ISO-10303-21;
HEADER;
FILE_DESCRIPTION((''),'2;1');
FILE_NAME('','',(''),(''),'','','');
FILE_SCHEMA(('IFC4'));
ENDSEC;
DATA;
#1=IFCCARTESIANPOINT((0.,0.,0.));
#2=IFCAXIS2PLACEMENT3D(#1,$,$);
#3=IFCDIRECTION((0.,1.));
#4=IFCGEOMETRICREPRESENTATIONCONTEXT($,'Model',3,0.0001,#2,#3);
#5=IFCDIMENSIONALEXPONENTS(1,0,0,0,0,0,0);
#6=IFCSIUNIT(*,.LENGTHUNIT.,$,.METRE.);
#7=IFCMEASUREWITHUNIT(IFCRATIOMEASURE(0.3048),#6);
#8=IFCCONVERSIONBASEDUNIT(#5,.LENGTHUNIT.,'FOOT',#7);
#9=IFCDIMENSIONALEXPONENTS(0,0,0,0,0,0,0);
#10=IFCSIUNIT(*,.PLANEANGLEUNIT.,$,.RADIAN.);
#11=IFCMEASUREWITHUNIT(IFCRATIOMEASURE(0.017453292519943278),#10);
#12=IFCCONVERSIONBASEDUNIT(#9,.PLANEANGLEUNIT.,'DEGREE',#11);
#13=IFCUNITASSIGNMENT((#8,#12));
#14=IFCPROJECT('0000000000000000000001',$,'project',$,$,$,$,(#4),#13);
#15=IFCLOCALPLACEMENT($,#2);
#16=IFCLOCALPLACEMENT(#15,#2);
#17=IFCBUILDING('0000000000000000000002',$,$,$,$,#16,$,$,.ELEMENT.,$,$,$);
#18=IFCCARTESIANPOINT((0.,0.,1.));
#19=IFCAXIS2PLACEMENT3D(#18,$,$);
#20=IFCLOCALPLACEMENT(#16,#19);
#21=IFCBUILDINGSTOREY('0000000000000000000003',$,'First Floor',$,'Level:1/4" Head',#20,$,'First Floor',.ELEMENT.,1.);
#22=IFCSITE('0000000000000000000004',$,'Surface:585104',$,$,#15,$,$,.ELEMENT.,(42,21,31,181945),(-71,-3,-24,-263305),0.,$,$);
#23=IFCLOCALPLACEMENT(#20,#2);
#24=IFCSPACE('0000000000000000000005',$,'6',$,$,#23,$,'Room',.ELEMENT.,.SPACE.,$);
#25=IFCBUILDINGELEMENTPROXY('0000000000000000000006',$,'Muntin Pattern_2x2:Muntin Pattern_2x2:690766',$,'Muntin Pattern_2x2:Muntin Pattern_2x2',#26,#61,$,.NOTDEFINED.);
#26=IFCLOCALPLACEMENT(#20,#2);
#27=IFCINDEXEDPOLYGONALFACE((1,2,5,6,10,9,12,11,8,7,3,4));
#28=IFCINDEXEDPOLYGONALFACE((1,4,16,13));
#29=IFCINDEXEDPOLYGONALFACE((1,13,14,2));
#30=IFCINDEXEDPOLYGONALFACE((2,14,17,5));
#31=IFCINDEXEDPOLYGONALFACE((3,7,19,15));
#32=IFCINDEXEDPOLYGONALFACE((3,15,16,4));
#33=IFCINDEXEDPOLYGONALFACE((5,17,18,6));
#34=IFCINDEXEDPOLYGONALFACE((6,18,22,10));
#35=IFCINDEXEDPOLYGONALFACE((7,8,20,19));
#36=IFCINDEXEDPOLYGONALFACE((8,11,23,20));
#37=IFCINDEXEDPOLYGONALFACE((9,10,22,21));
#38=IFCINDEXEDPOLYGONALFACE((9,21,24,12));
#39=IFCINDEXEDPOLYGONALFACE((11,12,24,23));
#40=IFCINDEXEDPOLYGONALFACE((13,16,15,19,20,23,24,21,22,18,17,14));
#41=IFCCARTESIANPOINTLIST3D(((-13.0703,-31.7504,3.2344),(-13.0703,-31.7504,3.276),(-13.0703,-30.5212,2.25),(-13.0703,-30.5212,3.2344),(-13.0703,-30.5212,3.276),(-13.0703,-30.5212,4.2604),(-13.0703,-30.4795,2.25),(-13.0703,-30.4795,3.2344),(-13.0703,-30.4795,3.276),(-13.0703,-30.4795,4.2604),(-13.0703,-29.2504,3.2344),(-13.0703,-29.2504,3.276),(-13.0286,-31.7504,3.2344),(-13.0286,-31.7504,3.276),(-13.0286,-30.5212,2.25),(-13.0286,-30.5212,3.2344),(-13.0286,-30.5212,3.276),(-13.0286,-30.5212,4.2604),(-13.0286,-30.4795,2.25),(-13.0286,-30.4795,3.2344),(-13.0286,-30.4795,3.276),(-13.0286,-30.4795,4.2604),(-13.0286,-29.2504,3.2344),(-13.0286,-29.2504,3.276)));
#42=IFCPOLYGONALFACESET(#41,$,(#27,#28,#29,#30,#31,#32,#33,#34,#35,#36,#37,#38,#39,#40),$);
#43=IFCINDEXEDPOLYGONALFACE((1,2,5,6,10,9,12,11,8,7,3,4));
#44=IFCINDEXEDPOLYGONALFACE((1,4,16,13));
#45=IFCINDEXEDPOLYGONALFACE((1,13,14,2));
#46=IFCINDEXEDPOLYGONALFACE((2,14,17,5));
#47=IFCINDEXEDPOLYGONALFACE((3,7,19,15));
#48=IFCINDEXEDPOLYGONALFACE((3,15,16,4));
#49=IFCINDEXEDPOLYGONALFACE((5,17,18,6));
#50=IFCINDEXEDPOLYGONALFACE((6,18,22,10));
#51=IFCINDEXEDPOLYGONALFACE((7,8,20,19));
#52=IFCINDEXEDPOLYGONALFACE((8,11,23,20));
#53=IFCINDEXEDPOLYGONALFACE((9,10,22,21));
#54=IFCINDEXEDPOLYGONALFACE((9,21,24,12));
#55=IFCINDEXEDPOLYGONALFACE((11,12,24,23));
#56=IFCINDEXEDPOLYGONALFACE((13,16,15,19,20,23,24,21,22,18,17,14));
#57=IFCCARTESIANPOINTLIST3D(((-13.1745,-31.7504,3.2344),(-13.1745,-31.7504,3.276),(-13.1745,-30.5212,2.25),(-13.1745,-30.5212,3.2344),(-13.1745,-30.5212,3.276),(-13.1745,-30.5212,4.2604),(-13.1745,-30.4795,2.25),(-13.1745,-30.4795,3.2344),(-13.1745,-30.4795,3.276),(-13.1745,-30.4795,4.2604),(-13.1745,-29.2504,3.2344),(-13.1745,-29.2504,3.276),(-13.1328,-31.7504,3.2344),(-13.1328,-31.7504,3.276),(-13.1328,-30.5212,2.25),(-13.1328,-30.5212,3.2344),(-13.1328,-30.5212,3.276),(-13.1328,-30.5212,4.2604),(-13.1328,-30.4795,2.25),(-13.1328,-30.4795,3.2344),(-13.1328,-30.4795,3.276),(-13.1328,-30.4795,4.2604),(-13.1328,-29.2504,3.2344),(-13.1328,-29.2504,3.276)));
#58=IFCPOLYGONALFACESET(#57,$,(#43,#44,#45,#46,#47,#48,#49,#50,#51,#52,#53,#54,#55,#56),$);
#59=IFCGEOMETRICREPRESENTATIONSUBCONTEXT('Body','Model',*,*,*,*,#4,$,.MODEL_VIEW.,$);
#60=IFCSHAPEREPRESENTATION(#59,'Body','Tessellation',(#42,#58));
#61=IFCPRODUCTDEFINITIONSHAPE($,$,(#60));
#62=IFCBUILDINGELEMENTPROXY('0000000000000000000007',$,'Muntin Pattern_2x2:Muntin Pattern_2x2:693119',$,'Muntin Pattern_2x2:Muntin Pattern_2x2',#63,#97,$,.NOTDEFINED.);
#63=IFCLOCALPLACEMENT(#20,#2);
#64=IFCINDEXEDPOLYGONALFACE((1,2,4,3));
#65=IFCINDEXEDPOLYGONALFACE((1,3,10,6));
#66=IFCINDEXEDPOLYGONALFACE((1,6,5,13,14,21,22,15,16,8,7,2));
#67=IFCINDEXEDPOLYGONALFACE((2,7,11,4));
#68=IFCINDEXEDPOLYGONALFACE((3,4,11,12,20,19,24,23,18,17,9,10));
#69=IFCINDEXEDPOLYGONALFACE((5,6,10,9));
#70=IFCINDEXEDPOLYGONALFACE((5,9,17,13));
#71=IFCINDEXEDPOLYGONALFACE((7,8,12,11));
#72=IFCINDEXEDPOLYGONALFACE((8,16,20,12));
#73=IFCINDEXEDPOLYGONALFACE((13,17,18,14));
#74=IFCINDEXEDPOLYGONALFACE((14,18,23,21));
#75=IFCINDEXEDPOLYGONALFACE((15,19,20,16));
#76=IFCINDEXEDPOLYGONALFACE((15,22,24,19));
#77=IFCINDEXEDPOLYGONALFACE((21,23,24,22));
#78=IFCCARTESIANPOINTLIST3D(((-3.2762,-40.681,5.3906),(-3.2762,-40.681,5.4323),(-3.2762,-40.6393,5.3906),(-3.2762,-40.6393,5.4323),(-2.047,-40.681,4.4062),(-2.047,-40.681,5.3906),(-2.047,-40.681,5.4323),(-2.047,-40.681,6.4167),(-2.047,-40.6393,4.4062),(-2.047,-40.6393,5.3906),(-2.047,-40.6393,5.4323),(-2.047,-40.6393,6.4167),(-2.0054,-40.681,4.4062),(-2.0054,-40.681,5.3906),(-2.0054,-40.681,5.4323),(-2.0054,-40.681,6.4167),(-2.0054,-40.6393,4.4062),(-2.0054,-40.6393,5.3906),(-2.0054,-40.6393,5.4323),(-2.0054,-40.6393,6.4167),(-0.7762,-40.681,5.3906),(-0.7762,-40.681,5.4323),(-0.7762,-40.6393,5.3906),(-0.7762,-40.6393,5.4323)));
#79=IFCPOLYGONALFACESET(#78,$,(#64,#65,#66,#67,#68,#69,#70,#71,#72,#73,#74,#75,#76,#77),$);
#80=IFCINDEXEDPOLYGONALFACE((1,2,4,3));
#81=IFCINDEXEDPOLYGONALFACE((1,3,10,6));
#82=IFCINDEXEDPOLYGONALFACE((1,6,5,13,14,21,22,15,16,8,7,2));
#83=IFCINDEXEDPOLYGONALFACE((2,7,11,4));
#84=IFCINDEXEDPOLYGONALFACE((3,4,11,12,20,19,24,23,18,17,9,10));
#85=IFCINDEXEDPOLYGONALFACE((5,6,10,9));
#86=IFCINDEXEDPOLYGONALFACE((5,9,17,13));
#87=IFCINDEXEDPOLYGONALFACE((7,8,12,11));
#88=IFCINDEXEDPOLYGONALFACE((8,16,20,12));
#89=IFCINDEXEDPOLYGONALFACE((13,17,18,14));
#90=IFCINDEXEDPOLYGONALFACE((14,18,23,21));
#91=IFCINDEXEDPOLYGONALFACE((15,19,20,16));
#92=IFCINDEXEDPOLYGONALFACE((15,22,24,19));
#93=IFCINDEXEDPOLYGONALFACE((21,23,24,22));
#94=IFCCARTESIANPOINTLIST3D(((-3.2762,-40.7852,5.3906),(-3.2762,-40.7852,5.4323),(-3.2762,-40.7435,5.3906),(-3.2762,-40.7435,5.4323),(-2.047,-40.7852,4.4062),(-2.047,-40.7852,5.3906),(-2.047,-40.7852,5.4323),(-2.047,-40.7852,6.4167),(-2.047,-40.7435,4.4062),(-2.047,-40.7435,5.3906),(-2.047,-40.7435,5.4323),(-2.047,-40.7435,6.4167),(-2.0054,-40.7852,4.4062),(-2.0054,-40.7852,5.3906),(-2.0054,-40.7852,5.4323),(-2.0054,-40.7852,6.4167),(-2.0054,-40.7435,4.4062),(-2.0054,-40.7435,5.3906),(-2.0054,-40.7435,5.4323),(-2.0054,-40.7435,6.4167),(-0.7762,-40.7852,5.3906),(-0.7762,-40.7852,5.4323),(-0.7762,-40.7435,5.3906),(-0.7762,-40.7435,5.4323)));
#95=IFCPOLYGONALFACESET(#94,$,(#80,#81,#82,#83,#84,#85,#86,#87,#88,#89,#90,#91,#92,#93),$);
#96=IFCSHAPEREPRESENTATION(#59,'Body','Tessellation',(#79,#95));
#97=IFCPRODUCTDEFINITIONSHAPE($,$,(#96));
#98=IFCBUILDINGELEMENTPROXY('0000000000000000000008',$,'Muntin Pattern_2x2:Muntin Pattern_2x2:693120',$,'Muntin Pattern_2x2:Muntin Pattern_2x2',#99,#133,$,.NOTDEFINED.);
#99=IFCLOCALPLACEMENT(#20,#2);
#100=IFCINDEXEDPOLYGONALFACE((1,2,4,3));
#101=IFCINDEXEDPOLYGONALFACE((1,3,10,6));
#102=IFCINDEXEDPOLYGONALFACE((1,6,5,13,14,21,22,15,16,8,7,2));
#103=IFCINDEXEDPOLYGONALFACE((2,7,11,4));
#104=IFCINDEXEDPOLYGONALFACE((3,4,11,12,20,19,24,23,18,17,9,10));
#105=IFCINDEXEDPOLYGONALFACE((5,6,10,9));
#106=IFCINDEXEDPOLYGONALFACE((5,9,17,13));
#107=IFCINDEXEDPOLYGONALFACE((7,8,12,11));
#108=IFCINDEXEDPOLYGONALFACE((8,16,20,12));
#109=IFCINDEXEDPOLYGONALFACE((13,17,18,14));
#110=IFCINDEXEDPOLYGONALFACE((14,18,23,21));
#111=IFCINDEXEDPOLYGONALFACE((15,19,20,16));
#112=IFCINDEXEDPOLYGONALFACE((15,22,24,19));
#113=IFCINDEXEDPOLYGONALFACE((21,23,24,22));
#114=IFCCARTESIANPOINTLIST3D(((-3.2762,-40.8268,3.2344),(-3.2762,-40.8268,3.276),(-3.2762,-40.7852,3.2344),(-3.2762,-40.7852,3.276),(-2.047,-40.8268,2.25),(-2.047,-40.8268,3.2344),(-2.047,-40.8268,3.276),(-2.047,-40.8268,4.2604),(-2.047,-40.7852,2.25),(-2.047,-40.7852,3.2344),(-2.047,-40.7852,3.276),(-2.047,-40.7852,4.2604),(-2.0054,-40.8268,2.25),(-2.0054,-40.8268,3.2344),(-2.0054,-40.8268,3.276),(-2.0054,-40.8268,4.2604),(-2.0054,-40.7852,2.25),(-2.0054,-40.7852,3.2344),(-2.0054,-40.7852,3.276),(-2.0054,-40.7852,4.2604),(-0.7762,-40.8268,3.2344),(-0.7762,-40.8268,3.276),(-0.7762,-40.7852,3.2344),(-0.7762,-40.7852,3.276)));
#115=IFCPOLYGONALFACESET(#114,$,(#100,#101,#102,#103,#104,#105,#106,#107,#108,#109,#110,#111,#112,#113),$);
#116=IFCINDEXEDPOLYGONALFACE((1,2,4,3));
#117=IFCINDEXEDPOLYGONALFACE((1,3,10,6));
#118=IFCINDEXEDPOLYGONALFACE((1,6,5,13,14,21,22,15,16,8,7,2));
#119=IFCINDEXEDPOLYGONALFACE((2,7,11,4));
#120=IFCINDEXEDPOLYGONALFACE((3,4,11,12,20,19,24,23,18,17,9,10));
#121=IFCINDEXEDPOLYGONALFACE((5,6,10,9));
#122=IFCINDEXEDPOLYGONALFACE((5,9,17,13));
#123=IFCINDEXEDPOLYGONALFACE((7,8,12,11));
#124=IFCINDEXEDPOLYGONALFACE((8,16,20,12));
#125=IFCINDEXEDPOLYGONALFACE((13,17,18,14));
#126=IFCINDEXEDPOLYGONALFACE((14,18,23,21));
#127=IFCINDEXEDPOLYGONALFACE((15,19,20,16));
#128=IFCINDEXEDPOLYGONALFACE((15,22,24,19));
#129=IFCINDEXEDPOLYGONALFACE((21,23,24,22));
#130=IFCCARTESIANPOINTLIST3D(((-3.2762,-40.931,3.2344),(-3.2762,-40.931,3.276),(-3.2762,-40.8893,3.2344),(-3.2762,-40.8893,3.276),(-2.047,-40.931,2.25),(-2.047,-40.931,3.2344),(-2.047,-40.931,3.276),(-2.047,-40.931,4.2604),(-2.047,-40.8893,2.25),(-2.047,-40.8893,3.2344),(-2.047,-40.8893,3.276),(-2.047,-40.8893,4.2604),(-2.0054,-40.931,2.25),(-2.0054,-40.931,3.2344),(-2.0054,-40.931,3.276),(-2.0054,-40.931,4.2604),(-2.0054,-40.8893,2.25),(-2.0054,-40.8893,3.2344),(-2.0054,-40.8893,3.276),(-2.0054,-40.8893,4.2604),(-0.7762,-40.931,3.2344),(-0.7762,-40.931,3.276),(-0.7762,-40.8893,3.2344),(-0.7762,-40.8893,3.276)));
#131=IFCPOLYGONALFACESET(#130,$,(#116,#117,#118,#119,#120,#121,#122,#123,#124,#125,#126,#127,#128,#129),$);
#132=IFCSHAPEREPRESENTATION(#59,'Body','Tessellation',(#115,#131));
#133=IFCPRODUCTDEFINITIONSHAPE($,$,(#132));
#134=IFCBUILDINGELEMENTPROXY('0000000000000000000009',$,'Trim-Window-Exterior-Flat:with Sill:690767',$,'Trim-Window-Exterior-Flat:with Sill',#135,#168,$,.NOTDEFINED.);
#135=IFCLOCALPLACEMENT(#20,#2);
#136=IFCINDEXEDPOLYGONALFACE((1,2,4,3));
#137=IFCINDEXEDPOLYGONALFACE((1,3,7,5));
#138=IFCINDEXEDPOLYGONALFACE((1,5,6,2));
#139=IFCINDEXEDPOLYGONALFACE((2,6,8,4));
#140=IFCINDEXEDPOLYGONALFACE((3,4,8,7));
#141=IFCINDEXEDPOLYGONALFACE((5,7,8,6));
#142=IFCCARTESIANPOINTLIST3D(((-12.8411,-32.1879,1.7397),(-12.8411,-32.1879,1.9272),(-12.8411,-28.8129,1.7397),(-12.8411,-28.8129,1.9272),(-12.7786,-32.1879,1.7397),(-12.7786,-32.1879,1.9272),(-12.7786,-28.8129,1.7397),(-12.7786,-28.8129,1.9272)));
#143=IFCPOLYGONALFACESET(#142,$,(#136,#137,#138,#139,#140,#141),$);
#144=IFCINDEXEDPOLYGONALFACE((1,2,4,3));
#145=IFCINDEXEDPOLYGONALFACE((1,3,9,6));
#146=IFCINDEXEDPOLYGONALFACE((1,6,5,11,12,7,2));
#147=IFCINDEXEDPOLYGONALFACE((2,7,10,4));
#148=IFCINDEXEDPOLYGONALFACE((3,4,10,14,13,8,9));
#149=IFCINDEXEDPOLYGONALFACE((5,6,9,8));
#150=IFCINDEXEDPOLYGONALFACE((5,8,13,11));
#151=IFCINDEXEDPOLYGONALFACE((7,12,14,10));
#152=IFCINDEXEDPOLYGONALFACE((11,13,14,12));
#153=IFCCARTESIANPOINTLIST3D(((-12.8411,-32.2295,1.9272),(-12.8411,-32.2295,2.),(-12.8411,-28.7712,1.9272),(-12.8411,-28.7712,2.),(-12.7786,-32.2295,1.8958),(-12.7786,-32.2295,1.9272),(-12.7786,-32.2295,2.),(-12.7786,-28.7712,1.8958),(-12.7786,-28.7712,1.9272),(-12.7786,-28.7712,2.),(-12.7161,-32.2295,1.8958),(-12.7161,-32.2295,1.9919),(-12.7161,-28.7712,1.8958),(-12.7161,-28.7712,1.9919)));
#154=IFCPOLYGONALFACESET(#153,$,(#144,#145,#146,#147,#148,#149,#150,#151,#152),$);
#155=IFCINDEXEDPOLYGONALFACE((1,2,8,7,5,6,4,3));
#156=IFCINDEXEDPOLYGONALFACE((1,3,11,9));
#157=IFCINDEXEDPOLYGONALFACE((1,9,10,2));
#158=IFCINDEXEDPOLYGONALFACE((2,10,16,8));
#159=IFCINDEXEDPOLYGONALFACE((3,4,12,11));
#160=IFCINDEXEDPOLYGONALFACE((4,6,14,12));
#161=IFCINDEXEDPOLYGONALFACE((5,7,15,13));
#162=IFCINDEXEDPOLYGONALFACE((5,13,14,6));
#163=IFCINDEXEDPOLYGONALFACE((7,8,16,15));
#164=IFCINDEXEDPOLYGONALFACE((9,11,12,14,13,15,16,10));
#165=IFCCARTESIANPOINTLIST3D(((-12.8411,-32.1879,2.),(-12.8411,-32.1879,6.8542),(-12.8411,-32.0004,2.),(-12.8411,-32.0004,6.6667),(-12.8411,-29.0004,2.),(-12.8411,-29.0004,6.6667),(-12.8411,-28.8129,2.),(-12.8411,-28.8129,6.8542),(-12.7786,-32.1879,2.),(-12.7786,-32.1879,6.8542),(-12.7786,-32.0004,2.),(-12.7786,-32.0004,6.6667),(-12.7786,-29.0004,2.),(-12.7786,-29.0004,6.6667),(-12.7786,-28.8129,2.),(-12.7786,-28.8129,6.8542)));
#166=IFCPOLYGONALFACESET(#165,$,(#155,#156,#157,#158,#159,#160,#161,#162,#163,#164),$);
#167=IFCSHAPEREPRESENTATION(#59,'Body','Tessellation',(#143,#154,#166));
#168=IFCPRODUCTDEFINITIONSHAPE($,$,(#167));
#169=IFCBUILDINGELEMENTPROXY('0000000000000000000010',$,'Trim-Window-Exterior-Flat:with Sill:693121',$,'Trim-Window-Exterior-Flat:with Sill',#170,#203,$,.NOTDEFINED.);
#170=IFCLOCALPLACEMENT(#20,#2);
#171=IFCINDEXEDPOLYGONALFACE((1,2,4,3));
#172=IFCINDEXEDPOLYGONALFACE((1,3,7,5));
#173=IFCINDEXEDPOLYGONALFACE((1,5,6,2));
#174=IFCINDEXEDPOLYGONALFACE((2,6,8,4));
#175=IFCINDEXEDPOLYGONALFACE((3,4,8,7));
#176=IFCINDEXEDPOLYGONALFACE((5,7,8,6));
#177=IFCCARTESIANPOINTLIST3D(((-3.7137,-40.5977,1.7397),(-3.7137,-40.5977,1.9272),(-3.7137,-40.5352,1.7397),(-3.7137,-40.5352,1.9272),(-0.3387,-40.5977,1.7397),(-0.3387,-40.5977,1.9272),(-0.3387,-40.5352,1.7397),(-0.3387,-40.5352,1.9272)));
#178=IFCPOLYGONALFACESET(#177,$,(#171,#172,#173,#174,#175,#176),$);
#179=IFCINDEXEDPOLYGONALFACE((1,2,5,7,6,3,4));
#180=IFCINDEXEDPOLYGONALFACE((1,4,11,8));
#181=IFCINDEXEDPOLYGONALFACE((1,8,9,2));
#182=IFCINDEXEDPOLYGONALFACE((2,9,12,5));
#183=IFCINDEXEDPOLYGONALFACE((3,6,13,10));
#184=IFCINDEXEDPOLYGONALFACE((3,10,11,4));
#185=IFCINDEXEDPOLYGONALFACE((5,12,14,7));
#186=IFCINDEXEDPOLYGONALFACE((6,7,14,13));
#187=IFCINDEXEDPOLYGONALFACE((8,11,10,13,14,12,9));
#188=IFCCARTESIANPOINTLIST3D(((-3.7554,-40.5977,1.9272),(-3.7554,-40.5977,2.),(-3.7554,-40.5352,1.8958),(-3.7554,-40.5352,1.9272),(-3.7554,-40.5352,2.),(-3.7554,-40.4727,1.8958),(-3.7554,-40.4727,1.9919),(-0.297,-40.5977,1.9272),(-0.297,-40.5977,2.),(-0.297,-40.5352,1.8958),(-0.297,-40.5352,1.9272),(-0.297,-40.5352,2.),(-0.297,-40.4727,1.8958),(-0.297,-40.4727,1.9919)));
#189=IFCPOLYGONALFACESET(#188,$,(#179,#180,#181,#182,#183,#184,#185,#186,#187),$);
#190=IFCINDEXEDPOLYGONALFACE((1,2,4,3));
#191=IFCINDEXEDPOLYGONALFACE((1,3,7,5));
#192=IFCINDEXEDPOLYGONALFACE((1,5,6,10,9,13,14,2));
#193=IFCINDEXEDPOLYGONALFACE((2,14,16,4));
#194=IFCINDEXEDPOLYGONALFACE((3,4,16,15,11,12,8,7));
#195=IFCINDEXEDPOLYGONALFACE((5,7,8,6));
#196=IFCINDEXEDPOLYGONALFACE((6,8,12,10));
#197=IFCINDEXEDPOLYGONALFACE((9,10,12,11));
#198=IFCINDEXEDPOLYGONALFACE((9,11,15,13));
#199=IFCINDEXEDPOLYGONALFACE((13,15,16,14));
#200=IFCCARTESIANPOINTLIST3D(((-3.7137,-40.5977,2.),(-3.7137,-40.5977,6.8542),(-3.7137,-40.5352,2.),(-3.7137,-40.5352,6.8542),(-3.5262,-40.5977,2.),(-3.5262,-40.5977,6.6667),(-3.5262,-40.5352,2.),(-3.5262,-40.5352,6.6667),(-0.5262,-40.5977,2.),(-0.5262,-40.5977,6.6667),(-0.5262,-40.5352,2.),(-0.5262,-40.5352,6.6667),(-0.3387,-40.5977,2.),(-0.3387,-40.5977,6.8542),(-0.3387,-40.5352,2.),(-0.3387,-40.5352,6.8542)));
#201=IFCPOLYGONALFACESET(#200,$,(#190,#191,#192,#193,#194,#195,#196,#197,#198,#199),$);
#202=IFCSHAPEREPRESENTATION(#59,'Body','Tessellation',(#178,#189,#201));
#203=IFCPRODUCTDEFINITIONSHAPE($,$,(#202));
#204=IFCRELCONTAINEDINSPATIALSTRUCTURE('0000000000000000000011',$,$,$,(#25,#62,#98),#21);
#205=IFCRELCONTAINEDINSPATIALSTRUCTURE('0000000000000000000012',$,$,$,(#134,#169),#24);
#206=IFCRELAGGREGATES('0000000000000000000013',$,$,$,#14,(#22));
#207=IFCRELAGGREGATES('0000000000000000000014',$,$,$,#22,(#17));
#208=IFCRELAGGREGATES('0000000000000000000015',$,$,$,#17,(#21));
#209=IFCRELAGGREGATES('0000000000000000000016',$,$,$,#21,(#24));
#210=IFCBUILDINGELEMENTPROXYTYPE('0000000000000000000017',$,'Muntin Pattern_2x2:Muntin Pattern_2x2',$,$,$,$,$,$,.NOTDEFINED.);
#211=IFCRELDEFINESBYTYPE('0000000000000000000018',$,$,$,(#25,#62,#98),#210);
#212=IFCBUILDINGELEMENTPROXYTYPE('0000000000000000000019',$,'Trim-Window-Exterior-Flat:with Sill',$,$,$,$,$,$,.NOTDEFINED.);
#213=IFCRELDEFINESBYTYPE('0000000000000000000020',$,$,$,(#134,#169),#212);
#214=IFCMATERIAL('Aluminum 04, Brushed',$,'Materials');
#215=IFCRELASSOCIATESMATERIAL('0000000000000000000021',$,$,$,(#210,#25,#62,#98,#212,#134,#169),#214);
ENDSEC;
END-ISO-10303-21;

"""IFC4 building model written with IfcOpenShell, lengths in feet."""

from ifc_helpers import new_model, entity, si_unit, converted_unit, direction, frame, origin, place, context, subcontext, project, spatial, indexed_curve, outline, extrude, source, transform, mapped, material, type_object, type_shapes, element, save


model = new_model("IFC4")

# Units and contexts
model_context = context("Model", 3, precision=0.0001, world=origin(), true_north=direction((0.0, 1.0)))
body_context = subcontext(model_context, "Body", "Model", "MODEL_VIEW")
ifc_project = project(units=[converted_unit("LENGTHUNIT", "FOOT", entity("IfcRatioMeasure", 0.3048), si_unit("LENGTHUNIT", "METRE"), dimensions=[1, 0, 0, 0, 0, 0, 0]), converted_unit("PLANEANGLEUNIT", "DEGREE", entity("IfcRatioMeasure", 0.017453292519943278), si_unit("PLANEANGLEUNIT", "RADIAN"), dimensions=[0, 0, 0, 0, 0, 0, 0])], contexts=[model_context])

# Site, building, storey
site_placement = place(None, origin())
site = spatial("IfcSite", under=ifc_project, at=site_placement, Name="Surface:585104", CompositionType="ELEMENT", RefLatitude=(42, 21, 31, 181945), RefLongitude=(-71, -3, -24, -263305), RefElevation=0.0)
building_placement = place(site_placement, origin())
building = spatial("IfcBuilding", under=site, at=building_placement, CompositionType="ELEMENT")
storey_placement = place(building_placement, frame((0.0, 0.0, 1.0)))
storey = spatial("IfcBuildingStorey", under=building, at=storey_placement, Name="First Floor", ObjectType="Level:1/4\" Head", LongName="First Floor", CompositionType="ELEMENT", Elevation=1.0)

# Shared definitions
ifc_material_1 = material(Name="Aluminum 04, Brushed", Category="Materials")

# Building element proxies
building_element_proxy_type_1 = type_object("IfcBuildingElementProxyType", Name="Muntin Pattern_2x2:Muntin Pattern_2x2", PredefinedType="NOTDEFINED", material=ifc_material_1)
shared_shape_1 = source(origin(), body_context, "Body", "SweptSolid", [
    extrude(outline(indexed_curve([(0.0208, -0.0208), (1.0052, -0.0208), (1.0052, 0.0208), (0.0208, 0.0208), (0.0208, 1.25), (-0.0208, 1.25), (-0.0208, 0.0208), (-1.0052, 0.0208), (-1.0052, -0.0208), (-0.0208, -0.0208), (-0.0208, -1.25), (0.0208, -1.25), (0.0208, -0.0208)], self_intersect=False)), frame((0.0, 0.0312, 1.0052), z_axis=(0.0, 1.0, 0.0), x_axis=(0.0, 0.0, 1.0)), (0.0, 0.0, 1.0), 0.0417),
    extrude(outline(indexed_curve([(0.0208, -0.0208), (1.0052, -0.0208), (1.0052, 0.0208), (0.0208, 0.0208), (0.0208, 1.25), (-0.0208, 1.25), (-0.0208, 0.0208), (-1.0052, 0.0208), (-1.0052, -0.0208), (-0.0208, -0.0208), (-0.0208, -1.25), (0.0208, -1.25), (0.0208, -0.0208)], self_intersect=False)), frame((0.0, -0.0729, 1.0052), z_axis=(0.0, 1.0, 0.0), x_axis=(0.0, 0.0, 1.0)), (0.0, 0.0, 1.0), 0.0417),
])
type_shapes(building_element_proxy_type_1, [shared_shape_1])
for number, where, z_axis, x_axis, name in (
    (1, (-13.1015, -30.5004, 2.25), (0.0, 0.0, 1.0), (0.0, -1.0, 0.0), "Muntin Pattern_2x2:Muntin Pattern_2x2:690766"),
):
    element("IfcBuildingElementProxy", number, at=place(storey_placement, frame(where, z_axis=z_axis, x_axis=x_axis)), inside=storey, type_object=building_element_proxy_type_1, material=ifc_material_1, Name=name, ObjectType="Muntin Pattern_2x2:Muntin Pattern_2x2", PredefinedType="NOTDEFINED", context=body_context, shape_type="MappedRepresentation", body=[
        mapped(shared_shape_1, transform((0.0, 0.0, 0.0), scale=1.0)),
    ])
for number, where, name in (
    (2, (-2.0262, -40.7122, 4.4062), "Muntin Pattern_2x2:Muntin Pattern_2x2:693119"),
    (3, (-2.0262, -40.8581, 2.25), "Muntin Pattern_2x2:Muntin Pattern_2x2:693120"),
):
    element("IfcBuildingElementProxy", number, at=place(storey_placement, frame(where)), inside=storey, type_object=building_element_proxy_type_1, material=ifc_material_1, Name=name, ObjectType="Muntin Pattern_2x2:Muntin Pattern_2x2", PredefinedType="NOTDEFINED", context=body_context, shape_type="MappedRepresentation", body=[
        mapped(shared_shape_1, transform((0.0, 0.0, 0.0), scale=1.0)),
    ])

# Shared definitions
space_placement = place(storey_placement, origin())
space = spatial("IfcSpace", under=storey, at=space_placement, Name="6", LongName="Room", CompositionType="ELEMENT", PredefinedType="SPACE")

# Building element proxies
building_element_proxy_type_2 = type_object("IfcBuildingElementProxyType", Name="Trim-Window-Exterior-Flat:with Sill", PredefinedType="NOTDEFINED", material=ifc_material_1)
shared_shape_2 = source(origin(), body_context, "Body", "SweptSolid", [
    extrude(outline(indexed_curve([(-1.6875, -0.0938), (1.6875, -0.0938), (1.6875, 0.0938), (-1.6875, 0.0938), (-1.6875, -0.0938)], self_intersect=False)), frame((0.0, -4.8332, 0.0), z_axis=(0.0, 0.0, 1.0), x_axis=(-1.0, 0.0, 0.0)), (0.0, 0.0, 1.0), 0.0625),
    extrude(outline(indexed_curve([(-0.0625, -0.0525), (0.0, -0.0525), (0.0, -0.0211), (0.0625, -0.0211), (0.0625, 0.0517), (0.0, 0.0517), (-0.0625, 0.0436), (-0.0625, -0.0525)], self_intersect=False)), frame((-1.7292, -4.7184, 0.0625), z_axis=(1.0, 0.0, 0.0), x_axis=(0.0, 0.0, -1.0)), (0.0, 0.0, 1.0), 3.4583),
    extrude(outline(indexed_curve([(-2.474, -1.6875), (2.3802, -1.6875), (2.3802, -1.5), (-2.2865, -1.5), (-2.2865, 1.5), (2.3802, 1.5), (2.3802, 1.6875), (-2.474, 1.6875), (-2.474, -1.6875)], self_intersect=False)), frame((0.0, -2.2865, 0.0), z_axis=(0.0, 0.0, 1.0), x_axis=(0.0, -1.0, 0.0)), (0.0, 0.0, 1.0), 0.0625),
])
type_shapes(building_element_proxy_type_2, [shared_shape_2])
for number, where, z_axis, x_axis, name in (
    (4, (-12.8411, -30.5004, 6.6667), (1.0, 0.0, 0.0), (0.0, 1.0, 0.0), "Trim-Window-Exterior-Flat:with Sill:690767"),
    (5, (-2.0262, -40.5977, 6.6667), (0.0, 1.0, 0.0), (-1.0, 0.0, 0.0), "Trim-Window-Exterior-Flat:with Sill:693121"),
):
    element("IfcBuildingElementProxy", number, at=place(space_placement, frame(where, z_axis=z_axis, x_axis=x_axis)), inside=space, type_object=building_element_proxy_type_2, material=ifc_material_1, Name=name, ObjectType="Trim-Window-Exterior-Flat:with Sill", PredefinedType="NOTDEFINED", context=body_context, shape_type="MappedRepresentation", body=[
        mapped(shared_shape_2, transform((0.0, 0.0, 0.0), scale=1.0)),
    ])

save(model, "model.ifc")
